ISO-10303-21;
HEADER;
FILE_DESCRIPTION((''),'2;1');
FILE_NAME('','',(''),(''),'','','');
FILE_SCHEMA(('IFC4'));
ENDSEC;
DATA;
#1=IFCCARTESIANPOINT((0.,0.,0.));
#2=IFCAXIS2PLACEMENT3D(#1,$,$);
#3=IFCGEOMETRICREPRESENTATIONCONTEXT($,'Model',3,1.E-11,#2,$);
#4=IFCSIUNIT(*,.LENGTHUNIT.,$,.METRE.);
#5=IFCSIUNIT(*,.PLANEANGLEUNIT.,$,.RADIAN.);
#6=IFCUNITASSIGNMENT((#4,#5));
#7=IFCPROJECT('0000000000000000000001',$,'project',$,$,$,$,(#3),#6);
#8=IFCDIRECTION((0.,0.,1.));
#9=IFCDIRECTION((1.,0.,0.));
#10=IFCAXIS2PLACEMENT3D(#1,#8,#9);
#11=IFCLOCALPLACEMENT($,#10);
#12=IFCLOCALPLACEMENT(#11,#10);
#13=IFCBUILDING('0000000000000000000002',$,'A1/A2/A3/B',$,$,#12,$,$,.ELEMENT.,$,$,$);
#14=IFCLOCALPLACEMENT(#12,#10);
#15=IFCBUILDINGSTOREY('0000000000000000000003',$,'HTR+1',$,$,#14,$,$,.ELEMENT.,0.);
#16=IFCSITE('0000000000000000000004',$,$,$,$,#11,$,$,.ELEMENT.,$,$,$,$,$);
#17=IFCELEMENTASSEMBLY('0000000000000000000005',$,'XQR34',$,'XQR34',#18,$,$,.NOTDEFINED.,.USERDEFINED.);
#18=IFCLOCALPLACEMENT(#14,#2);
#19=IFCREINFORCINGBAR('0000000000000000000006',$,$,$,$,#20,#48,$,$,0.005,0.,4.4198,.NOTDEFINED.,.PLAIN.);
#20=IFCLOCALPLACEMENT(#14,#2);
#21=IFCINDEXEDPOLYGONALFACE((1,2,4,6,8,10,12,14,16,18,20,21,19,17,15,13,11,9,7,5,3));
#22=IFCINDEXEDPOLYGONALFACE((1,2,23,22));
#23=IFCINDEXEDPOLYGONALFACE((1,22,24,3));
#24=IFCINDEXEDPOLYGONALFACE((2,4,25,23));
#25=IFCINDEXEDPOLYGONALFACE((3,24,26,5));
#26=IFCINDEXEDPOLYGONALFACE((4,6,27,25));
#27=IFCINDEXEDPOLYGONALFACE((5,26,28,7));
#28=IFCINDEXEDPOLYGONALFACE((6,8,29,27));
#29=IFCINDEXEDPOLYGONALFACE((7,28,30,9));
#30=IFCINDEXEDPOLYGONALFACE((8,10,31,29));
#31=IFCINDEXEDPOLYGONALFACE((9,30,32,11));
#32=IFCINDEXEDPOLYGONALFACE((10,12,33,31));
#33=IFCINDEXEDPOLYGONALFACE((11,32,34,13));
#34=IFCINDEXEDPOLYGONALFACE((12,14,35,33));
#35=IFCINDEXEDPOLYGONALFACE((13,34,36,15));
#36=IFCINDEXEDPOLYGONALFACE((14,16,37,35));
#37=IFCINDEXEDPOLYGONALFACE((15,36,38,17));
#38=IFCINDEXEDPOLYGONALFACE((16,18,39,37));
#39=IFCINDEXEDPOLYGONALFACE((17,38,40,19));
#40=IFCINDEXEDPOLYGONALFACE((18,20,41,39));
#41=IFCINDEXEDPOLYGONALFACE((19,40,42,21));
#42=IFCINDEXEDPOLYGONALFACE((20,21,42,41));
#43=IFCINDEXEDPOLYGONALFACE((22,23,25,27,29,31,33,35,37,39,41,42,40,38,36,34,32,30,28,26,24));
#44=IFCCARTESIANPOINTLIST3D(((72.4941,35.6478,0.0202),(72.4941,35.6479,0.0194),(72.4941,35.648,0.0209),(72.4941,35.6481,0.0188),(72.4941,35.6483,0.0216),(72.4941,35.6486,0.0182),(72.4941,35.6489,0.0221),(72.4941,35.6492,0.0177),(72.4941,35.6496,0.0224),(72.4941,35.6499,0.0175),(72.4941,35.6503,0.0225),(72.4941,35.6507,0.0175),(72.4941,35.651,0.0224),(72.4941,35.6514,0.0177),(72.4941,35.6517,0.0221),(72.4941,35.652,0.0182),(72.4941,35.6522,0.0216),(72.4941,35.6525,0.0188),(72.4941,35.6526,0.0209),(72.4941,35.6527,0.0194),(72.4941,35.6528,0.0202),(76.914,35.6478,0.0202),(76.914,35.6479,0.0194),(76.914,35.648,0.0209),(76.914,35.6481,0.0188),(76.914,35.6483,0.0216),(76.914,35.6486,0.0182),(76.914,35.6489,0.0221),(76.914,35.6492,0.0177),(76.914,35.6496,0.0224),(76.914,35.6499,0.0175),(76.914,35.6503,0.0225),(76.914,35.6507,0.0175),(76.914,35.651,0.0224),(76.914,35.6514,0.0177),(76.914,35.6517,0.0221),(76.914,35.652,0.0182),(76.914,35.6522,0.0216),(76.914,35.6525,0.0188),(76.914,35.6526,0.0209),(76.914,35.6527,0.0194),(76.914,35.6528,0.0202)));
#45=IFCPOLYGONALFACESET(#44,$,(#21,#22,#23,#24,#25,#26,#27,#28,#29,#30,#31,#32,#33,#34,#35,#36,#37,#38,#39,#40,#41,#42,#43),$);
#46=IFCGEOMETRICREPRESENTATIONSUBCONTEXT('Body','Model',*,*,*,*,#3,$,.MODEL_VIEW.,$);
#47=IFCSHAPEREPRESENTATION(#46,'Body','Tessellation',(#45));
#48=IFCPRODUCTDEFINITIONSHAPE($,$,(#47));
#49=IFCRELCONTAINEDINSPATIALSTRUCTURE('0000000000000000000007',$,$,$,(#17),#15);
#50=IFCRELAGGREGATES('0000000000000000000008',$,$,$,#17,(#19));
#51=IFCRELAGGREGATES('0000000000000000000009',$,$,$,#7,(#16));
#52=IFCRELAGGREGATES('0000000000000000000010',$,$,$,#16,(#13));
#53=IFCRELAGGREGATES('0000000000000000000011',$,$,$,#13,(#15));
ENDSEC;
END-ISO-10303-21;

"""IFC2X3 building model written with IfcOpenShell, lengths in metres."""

from ifc_helpers import new_model, entity, si_unit, origin, origin_with_axes, place, context, subcontext, project, spatial, shape, element, aggregate, save


model = new_model("IFC2X3")

# Units and contexts
model_context = context("Model", 3, precision=1e-11, world=origin())
body_context = subcontext(model_context, "Body", "Model", "MODEL_VIEW")
ifc_project = project(units=[si_unit("LENGTHUNIT", "METRE"), si_unit("PLANEANGLEUNIT", "RADIAN")], contexts=[model_context])

# Site, building, storey
site_placement = place(None, origin_with_axes())
site = spatial("IfcSite", under=ifc_project, at=site_placement, CompositionType="ELEMENT")
building_placement = place(site_placement, origin_with_axes())
building = spatial("IfcBuilding", under=site, at=building_placement, Name="A1/A2/A3/B", CompositionType="ELEMENT")
storey_placement = place(building_placement, origin_with_axes())
storey = spatial("IfcBuildingStorey", under=building, at=storey_placement, Name="HTR+1", CompositionType="ELEMENT", Elevation=0.0)

# Element assembly, reinforcing bar
assembly_1_placement = place(storey_placement, origin_with_axes())
assembly_1 = element("IfcElementAssembly", 1, at=assembly_1_placement, inside=storey, Name="XQR34", ObjectType="XQR34", AssemblyPlace="NOTDEFINED", PredefinedType="USERDEFINED")
reinforcing_bar_1_placement = place(assembly_1_placement, origin_with_axes())
reinforcing_bar_1 = element("IfcReinforcingBar", 2, at=reinforcing_bar_1_placement, BarLength=4.4198, BarRole="NOTDEFINED", BarSurface="PLAIN", CrossSectionArea=0.0, NominalDiameter=0.005, shapes=[
    shape(body_context, "Body", "AdvancedSweptSolid", [entity("IfcSweptDiskSolid", entity("IfcPolyline", [entity("IfcCartesianPoint", [72.4941, 35.6503, 0.02]), entity("IfcCartesianPoint", [76.914, 35.6503, 0.02])]), 0.0025, None, 0.0, 4.4198)]),
    shape(body_context, "Body", "AdvancedSweptSolid", [entity("IfcSweptDiskSolid", entity("IfcPolyline", [entity("IfcCartesianPoint", [72.4941, 35.6503, 0.02]), entity("IfcCartesianPoint", [76.914, 35.6503, 0.02])]), 0.0025, None, 0.0, 4.4198)]),
])
aggregate(assembly_1, [reinforcing_bar_1])

save(model, "model.ifc")
